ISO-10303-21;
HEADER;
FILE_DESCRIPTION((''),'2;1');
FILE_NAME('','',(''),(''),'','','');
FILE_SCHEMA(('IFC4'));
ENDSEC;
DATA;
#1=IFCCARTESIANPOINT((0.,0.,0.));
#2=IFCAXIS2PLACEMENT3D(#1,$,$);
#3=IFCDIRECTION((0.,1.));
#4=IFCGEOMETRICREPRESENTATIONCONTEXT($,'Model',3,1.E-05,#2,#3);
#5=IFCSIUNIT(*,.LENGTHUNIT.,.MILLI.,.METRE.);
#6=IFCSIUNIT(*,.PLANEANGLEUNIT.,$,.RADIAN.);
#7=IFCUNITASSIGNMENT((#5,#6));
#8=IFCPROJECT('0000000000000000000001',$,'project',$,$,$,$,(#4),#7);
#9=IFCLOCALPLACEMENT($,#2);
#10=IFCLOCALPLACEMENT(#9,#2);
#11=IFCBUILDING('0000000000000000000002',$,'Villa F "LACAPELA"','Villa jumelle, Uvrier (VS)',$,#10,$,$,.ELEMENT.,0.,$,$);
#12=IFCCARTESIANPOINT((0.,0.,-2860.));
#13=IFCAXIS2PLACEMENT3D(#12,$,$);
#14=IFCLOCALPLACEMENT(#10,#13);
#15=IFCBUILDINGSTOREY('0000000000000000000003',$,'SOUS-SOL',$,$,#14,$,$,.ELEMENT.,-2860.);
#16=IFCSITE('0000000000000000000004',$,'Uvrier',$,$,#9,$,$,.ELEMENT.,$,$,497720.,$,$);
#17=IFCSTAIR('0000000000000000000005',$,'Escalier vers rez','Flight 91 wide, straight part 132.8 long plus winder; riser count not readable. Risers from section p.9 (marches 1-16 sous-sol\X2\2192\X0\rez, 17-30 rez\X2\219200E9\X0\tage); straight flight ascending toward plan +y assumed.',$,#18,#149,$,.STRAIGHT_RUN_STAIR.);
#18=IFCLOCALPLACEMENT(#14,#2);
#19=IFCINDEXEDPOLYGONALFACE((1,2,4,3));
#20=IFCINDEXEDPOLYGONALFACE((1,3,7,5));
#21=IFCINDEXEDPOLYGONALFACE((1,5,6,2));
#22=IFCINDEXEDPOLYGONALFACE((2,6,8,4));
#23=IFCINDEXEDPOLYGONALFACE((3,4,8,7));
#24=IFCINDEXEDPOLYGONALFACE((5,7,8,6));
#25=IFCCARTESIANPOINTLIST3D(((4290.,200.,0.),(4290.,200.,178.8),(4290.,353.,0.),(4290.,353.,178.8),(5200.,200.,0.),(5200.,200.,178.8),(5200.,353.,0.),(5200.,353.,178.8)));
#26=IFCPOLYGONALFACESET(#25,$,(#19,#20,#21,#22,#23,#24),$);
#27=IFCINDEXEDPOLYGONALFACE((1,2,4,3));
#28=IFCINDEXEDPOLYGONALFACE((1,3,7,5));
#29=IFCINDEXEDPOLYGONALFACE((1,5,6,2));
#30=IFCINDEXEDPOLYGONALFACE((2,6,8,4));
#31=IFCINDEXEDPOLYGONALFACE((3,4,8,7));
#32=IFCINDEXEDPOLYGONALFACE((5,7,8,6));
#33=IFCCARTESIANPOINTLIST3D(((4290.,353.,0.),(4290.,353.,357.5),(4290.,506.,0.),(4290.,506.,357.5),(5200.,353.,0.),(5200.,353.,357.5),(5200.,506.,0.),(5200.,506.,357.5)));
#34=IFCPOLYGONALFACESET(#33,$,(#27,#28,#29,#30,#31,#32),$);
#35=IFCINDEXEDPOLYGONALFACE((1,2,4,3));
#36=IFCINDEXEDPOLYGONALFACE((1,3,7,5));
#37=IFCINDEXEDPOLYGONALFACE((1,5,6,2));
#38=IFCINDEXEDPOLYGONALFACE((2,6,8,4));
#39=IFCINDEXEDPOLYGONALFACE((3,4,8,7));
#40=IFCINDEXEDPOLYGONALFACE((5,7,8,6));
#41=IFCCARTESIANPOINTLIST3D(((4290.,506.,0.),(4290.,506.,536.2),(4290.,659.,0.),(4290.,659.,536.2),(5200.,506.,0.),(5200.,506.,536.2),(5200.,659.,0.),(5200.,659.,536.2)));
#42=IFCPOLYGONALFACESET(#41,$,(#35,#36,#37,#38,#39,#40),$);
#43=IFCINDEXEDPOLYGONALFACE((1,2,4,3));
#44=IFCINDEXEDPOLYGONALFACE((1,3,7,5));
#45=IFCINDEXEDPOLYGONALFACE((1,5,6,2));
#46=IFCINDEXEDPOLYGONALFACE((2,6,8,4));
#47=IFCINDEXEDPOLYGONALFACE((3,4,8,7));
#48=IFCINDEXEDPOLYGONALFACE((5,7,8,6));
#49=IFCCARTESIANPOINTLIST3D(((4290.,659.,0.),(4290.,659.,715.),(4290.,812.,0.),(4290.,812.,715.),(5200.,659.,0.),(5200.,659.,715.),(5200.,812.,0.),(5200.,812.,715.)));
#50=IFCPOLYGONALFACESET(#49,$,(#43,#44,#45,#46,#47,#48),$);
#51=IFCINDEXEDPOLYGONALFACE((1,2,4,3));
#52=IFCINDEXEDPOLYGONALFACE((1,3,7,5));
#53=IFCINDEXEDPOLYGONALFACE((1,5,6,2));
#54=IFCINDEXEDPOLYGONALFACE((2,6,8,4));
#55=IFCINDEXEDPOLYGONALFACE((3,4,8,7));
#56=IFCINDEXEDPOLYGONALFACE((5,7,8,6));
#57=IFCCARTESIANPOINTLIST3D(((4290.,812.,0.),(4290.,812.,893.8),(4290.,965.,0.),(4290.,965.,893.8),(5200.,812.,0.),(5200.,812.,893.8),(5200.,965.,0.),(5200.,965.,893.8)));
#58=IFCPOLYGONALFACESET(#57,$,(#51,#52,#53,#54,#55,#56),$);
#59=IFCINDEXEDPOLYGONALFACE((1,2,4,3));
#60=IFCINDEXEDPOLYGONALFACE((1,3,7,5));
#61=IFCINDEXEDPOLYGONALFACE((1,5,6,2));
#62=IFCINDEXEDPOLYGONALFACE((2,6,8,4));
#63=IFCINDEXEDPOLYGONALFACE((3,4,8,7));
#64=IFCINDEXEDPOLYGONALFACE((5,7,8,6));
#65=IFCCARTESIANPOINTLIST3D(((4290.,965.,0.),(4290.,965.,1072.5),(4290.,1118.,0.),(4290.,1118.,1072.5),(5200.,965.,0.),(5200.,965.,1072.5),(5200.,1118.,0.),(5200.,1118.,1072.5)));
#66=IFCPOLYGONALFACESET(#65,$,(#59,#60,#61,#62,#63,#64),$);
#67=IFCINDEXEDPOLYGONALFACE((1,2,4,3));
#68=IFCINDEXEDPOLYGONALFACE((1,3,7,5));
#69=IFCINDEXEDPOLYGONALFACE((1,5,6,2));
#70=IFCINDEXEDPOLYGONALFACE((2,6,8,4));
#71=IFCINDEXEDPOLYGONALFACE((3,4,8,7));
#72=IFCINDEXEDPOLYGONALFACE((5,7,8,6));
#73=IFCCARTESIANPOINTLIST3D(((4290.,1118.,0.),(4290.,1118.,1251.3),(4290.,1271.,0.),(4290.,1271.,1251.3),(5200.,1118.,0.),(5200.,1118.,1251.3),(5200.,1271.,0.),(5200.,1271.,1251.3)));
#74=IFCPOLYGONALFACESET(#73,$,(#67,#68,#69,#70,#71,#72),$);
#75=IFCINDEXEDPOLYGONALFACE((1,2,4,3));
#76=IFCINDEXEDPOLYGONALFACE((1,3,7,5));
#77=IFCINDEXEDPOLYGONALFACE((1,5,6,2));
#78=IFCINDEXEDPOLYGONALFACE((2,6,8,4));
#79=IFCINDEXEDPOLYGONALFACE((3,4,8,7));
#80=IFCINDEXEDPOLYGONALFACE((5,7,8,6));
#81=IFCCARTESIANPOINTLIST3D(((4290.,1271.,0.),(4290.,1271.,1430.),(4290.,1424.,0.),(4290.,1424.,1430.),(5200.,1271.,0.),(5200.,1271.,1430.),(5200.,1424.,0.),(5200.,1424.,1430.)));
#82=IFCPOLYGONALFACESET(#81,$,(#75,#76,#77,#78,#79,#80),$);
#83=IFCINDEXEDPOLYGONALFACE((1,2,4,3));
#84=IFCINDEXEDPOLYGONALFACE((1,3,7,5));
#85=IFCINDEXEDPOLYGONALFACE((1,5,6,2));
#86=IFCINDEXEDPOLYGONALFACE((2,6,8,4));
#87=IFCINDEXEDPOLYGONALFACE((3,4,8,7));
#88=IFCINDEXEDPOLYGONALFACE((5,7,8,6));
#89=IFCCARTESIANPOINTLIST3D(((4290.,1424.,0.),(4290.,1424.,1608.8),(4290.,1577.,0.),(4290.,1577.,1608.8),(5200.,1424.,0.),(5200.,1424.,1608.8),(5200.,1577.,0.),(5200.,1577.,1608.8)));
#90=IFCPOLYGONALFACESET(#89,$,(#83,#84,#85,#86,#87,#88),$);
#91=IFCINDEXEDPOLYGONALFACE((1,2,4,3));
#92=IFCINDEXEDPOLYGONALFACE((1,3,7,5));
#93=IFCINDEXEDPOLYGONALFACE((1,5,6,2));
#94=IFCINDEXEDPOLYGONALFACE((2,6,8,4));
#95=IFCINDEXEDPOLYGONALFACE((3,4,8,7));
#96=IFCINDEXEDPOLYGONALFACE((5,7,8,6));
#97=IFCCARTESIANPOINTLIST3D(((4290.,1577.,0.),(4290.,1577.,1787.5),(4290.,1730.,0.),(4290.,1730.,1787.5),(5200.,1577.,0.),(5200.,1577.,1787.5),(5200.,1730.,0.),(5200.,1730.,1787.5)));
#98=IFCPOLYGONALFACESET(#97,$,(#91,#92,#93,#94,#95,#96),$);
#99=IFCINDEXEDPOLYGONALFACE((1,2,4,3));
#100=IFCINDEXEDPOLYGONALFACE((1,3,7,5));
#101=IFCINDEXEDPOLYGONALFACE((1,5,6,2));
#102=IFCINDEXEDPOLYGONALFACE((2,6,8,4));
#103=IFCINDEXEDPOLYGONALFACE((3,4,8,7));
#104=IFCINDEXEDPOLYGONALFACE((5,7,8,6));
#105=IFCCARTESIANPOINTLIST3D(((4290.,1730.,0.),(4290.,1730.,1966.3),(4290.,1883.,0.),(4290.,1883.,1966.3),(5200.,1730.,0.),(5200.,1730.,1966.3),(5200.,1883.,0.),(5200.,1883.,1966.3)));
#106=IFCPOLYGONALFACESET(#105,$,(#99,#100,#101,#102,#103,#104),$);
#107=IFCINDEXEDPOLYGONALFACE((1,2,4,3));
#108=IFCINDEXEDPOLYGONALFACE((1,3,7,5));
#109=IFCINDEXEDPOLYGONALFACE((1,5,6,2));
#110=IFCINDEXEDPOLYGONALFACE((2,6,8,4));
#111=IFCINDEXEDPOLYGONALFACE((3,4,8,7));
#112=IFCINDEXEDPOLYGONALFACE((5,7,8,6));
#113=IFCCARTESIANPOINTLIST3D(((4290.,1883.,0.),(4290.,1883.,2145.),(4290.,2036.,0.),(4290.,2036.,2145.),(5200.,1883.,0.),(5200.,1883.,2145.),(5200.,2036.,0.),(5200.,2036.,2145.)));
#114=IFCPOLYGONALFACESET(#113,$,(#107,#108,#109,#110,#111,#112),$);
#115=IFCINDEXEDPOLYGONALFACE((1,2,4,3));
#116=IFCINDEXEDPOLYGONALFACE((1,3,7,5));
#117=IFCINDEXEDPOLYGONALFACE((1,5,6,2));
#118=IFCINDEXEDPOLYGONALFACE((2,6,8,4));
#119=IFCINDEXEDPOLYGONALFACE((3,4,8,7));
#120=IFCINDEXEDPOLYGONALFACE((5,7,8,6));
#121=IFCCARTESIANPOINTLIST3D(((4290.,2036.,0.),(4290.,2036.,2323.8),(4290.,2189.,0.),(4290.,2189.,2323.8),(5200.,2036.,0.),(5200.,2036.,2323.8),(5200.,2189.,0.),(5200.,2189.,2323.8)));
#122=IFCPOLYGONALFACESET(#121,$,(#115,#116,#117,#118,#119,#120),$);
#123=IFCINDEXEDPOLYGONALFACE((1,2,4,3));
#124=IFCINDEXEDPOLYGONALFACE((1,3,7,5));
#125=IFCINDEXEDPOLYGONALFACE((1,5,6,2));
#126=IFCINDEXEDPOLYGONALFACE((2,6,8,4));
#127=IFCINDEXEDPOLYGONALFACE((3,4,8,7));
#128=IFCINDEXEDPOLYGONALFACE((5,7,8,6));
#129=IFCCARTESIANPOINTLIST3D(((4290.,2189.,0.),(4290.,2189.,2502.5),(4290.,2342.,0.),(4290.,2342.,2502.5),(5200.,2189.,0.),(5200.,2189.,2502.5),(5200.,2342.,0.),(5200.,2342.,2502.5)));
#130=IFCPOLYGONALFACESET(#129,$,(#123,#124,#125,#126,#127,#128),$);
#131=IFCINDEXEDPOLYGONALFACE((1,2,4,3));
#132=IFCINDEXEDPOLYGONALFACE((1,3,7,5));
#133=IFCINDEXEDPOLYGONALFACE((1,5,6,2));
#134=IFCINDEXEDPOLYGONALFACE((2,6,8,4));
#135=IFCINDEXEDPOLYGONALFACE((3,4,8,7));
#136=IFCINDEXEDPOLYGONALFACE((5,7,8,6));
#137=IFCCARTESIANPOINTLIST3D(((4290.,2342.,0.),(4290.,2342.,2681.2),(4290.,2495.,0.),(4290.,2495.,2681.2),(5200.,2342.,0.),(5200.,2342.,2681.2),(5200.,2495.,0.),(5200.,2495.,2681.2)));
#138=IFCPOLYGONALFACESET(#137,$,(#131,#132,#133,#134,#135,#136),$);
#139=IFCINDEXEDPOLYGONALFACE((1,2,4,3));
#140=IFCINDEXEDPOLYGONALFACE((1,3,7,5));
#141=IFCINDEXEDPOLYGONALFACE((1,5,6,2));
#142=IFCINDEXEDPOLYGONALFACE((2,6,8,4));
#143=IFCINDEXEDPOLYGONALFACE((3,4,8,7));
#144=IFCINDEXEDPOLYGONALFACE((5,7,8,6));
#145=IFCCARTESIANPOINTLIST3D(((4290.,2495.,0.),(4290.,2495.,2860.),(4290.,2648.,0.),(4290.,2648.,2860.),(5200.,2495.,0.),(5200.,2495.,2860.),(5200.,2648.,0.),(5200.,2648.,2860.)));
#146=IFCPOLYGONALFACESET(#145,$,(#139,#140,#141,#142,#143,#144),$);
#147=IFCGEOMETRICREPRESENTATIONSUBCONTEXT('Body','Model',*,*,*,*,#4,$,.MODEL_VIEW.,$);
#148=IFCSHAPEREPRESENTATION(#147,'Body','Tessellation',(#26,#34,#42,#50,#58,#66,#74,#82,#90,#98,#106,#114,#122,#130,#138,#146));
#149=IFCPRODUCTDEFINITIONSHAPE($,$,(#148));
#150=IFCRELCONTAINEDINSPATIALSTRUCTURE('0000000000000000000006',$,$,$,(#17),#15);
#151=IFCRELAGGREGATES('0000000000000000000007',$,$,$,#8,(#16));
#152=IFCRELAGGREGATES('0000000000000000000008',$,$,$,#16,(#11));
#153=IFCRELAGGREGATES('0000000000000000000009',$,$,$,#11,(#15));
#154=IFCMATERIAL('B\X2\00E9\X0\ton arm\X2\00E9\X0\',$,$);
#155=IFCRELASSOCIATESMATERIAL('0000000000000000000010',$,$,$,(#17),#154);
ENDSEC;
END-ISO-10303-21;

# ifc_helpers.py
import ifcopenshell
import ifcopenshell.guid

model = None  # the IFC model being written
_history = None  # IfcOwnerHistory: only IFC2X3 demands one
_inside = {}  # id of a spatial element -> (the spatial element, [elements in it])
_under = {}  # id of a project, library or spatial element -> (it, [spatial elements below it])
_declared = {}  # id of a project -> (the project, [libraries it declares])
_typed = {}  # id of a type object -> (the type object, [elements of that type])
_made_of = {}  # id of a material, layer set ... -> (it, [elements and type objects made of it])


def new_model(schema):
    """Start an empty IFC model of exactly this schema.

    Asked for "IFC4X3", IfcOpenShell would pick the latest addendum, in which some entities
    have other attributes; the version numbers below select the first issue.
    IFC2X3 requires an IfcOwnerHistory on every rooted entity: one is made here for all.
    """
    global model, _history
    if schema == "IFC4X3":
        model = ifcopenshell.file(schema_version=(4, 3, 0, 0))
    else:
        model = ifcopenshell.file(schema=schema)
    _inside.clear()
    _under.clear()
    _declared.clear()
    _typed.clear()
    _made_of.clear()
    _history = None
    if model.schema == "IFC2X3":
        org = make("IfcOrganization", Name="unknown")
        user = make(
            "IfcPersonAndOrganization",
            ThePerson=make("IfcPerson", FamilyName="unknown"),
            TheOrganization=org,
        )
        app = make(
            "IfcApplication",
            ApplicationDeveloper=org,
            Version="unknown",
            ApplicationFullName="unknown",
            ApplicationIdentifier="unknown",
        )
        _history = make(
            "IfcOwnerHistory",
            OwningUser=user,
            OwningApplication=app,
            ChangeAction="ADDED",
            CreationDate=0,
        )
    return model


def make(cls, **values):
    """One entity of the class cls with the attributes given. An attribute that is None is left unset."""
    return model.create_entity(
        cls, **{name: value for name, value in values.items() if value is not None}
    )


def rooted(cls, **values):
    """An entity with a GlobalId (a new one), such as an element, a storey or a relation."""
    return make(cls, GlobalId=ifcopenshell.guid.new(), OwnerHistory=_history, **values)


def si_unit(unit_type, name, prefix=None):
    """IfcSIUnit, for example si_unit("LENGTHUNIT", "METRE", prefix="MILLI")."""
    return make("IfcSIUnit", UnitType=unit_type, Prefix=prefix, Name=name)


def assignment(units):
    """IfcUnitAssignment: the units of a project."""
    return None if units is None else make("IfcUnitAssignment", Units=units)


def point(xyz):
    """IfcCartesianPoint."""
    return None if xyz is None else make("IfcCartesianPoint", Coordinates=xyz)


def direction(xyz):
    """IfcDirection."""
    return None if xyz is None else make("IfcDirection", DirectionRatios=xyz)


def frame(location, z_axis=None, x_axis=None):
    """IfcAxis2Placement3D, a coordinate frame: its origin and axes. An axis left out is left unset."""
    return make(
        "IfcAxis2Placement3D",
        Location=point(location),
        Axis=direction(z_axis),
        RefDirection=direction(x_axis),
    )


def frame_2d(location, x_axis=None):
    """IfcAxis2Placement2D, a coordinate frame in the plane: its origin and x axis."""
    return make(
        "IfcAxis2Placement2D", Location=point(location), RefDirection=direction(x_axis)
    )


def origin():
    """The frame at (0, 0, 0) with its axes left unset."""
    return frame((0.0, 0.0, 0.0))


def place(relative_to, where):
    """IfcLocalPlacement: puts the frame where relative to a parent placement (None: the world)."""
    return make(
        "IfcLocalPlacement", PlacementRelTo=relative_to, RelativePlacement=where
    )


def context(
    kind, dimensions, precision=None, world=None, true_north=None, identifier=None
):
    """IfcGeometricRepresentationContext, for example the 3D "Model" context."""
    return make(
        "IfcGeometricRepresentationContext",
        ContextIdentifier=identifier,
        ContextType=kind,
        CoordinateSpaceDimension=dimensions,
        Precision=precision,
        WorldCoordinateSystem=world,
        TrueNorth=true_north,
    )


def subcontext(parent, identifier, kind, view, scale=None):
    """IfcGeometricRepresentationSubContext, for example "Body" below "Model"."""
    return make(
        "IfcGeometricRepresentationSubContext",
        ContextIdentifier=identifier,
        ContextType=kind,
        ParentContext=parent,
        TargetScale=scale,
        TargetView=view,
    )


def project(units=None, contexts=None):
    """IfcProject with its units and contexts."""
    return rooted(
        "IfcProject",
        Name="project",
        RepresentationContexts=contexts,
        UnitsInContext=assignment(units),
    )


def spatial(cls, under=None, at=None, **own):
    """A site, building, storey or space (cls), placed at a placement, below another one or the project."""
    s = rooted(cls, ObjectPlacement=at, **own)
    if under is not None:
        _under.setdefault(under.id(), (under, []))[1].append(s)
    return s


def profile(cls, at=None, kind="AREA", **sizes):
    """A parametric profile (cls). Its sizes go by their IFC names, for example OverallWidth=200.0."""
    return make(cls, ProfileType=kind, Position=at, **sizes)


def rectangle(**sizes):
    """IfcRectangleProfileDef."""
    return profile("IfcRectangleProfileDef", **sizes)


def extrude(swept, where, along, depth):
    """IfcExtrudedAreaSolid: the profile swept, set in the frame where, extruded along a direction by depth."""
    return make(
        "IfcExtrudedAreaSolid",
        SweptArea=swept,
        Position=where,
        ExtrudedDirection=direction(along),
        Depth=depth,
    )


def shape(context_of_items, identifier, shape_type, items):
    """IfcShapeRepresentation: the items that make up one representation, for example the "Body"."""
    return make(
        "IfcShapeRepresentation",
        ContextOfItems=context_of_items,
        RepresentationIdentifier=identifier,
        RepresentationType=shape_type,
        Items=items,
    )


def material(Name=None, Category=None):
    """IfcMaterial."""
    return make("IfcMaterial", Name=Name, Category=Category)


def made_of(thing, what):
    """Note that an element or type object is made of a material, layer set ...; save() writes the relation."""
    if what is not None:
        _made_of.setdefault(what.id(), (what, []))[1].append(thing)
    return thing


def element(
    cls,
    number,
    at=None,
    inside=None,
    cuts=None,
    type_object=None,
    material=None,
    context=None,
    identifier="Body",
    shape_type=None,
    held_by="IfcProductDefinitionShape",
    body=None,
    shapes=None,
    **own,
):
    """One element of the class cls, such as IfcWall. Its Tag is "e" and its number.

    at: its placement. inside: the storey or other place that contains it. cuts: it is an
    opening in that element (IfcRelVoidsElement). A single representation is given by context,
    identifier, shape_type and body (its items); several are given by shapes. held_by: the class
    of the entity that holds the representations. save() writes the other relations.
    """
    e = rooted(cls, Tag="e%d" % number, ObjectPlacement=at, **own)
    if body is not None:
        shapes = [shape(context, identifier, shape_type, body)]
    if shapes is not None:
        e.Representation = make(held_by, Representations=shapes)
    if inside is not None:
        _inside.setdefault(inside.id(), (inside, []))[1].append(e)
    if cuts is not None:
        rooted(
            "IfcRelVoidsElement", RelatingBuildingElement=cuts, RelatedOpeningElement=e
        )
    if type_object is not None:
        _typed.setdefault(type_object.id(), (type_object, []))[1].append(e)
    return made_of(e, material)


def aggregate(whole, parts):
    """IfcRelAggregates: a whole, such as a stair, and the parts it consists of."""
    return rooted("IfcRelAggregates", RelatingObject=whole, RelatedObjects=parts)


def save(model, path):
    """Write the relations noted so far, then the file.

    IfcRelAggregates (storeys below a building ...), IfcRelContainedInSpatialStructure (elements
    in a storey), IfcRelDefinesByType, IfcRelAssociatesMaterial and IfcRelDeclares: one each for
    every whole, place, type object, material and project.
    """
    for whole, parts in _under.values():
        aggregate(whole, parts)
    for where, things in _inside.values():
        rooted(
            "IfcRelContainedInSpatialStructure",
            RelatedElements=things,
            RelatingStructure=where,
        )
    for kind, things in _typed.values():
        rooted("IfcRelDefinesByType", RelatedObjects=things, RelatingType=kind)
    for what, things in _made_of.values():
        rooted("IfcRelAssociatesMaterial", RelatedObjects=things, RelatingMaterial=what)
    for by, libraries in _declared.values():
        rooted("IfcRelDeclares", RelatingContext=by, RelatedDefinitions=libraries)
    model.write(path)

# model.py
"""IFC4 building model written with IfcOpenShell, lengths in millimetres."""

from ifc_helpers import new_model, si_unit, direction, frame, frame_2d, origin, place, context, subcontext, project, spatial, rectangle, extrude, material, element, save


model = new_model("IFC4")

# Units and contexts
model_context = context("Model", 3, precision=1e-05, world=origin(), true_north=direction((0.0, 1.0)))
body_context = subcontext(model_context, "Body", "Model", "MODEL_VIEW")
ifc_project = project(units=[si_unit("LENGTHUNIT", "METRE", prefix="MILLI"), si_unit("PLANEANGLEUNIT", "RADIAN")], contexts=[model_context])

# Site, building, storey
site_placement = place(None, origin())
site = spatial("IfcSite", under=ifc_project, at=site_placement, Name="Uvrier", CompositionType="ELEMENT", RefElevation=497720.0)
building_placement = place(site_placement, origin())
building = spatial("IfcBuilding", under=site, at=building_placement, Name="Villa F \"LACAPELA\"", Description="Villa jumelle, Uvrier (VS)", CompositionType="ELEMENT", ElevationOfRefHeight=0.0)
storey_placement = place(building_placement, frame((0.0, 0.0, -2860.0)))
storey = spatial("IfcBuildingStorey", under=building, at=storey_placement, Name="SOUS-SOL", CompositionType="ELEMENT", Elevation=-2860.0)

# Shared definitions
ifc_material_1 = material(Name="Béton armé")

# Stair
stair_placement = place(storey_placement, origin())
element("IfcStair", 1, at=stair_placement, inside=storey, material=ifc_material_1, Name="Escalier vers rez", Description="Flight 91 wide, straight part 132.8 long plus winder; riser count not readable. Risers from section p.9 (marches 1-16 sous-sol→rez, 17-30 rez→étage); straight flight ascending toward plan +y assumed.", PredefinedType="STRAIGHT_RUN_STAIR", context=body_context, shape_type="SweptSolid", body=[
    extrude(rectangle(XDim=153.0, YDim=910.0, at=frame_2d((4745.0, 276.5), x_axis=(0.0, 1.0))), origin(), (0.0, 0.0, 1.0), 178.8),
    extrude(rectangle(XDim=153.0, YDim=910.0, at=frame_2d((4745.0, 429.5), x_axis=(0.0, 1.0))), origin(), (0.0, 0.0, 1.0), 357.5),
    extrude(rectangle(XDim=153.0, YDim=910.0, at=frame_2d((4745.0, 582.5), x_axis=(0.0, 1.0))), origin(), (0.0, 0.0, 1.0), 536.2),
    extrude(rectangle(XDim=153.0, YDim=910.0, at=frame_2d((4745.0, 735.5), x_axis=(0.0, 1.0))), origin(), (0.0, 0.0, 1.0), 715.0),
    extrude(rectangle(XDim=153.0, YDim=910.0, at=frame_2d((4745.0, 888.5), x_axis=(0.0, 1.0))), origin(), (0.0, 0.0, 1.0), 893.8),
    extrude(rectangle(XDim=153.0, YDim=910.0, at=frame_2d((4745.0, 1041.5), x_axis=(0.0, 1.0))), origin(), (0.0, 0.0, 1.0), 1072.5),
    extrude(rectangle(XDim=153.0, YDim=910.0, at=frame_2d((4745.0, 1194.5), x_axis=(0.0, 1.0))), origin(), (0.0, 0.0, 1.0), 1251.2),
    extrude(rectangle(XDim=153.0, YDim=910.0, at=frame_2d((4745.0, 1347.5), x_axis=(0.0, 1.0))), origin(), (0.0, 0.0, 1.0), 1430.0),
    extrude(rectangle(XDim=153.0, YDim=910.0, at=frame_2d((4745.0, 1500.5), x_axis=(0.0, 1.0))), origin(), (0.0, 0.0, 1.0), 1608.8),
    extrude(rectangle(XDim=153.0, YDim=910.0, at=frame_2d((4745.0, 1653.5), x_axis=(0.0, 1.0))), origin(), (0.0, 0.0, 1.0), 1787.5),
    extrude(rectangle(XDim=153.0, YDim=910.0, at=frame_2d((4745.0, 1806.5), x_axis=(0.0, 1.0))), origin(), (0.0, 0.0, 1.0), 1966.2),
    extrude(rectangle(XDim=153.0, YDim=910.0, at=frame_2d((4745.0, 1959.5), x_axis=(0.0, 1.0))), origin(), (0.0, 0.0, 1.0), 2145.0),
    extrude(rectangle(XDim=153.0, YDim=910.0, at=frame_2d((4745.0, 2112.5), x_axis=(0.0, 1.0))), origin(), (0.0, 0.0, 1.0), 2323.8),
    extrude(rectangle(XDim=153.0, YDim=910.0, at=frame_2d((4745.0, 2265.5), x_axis=(0.0, 1.0))), origin(), (0.0, 0.0, 1.0), 2502.5),
    extrude(rectangle(XDim=153.0, YDim=910.0, at=frame_2d((4745.0, 2418.5), x_axis=(0.0, 1.0))), origin(), (0.0, 0.0, 1.0), 2681.2),
    extrude(rectangle(XDim=153.0, YDim=910.0, at=frame_2d((4745.0, 2571.5), x_axis=(0.0, 1.0))), origin(), (0.0, 0.0, 1.0), 2860.0),
])

save(model, "model.ifc")
